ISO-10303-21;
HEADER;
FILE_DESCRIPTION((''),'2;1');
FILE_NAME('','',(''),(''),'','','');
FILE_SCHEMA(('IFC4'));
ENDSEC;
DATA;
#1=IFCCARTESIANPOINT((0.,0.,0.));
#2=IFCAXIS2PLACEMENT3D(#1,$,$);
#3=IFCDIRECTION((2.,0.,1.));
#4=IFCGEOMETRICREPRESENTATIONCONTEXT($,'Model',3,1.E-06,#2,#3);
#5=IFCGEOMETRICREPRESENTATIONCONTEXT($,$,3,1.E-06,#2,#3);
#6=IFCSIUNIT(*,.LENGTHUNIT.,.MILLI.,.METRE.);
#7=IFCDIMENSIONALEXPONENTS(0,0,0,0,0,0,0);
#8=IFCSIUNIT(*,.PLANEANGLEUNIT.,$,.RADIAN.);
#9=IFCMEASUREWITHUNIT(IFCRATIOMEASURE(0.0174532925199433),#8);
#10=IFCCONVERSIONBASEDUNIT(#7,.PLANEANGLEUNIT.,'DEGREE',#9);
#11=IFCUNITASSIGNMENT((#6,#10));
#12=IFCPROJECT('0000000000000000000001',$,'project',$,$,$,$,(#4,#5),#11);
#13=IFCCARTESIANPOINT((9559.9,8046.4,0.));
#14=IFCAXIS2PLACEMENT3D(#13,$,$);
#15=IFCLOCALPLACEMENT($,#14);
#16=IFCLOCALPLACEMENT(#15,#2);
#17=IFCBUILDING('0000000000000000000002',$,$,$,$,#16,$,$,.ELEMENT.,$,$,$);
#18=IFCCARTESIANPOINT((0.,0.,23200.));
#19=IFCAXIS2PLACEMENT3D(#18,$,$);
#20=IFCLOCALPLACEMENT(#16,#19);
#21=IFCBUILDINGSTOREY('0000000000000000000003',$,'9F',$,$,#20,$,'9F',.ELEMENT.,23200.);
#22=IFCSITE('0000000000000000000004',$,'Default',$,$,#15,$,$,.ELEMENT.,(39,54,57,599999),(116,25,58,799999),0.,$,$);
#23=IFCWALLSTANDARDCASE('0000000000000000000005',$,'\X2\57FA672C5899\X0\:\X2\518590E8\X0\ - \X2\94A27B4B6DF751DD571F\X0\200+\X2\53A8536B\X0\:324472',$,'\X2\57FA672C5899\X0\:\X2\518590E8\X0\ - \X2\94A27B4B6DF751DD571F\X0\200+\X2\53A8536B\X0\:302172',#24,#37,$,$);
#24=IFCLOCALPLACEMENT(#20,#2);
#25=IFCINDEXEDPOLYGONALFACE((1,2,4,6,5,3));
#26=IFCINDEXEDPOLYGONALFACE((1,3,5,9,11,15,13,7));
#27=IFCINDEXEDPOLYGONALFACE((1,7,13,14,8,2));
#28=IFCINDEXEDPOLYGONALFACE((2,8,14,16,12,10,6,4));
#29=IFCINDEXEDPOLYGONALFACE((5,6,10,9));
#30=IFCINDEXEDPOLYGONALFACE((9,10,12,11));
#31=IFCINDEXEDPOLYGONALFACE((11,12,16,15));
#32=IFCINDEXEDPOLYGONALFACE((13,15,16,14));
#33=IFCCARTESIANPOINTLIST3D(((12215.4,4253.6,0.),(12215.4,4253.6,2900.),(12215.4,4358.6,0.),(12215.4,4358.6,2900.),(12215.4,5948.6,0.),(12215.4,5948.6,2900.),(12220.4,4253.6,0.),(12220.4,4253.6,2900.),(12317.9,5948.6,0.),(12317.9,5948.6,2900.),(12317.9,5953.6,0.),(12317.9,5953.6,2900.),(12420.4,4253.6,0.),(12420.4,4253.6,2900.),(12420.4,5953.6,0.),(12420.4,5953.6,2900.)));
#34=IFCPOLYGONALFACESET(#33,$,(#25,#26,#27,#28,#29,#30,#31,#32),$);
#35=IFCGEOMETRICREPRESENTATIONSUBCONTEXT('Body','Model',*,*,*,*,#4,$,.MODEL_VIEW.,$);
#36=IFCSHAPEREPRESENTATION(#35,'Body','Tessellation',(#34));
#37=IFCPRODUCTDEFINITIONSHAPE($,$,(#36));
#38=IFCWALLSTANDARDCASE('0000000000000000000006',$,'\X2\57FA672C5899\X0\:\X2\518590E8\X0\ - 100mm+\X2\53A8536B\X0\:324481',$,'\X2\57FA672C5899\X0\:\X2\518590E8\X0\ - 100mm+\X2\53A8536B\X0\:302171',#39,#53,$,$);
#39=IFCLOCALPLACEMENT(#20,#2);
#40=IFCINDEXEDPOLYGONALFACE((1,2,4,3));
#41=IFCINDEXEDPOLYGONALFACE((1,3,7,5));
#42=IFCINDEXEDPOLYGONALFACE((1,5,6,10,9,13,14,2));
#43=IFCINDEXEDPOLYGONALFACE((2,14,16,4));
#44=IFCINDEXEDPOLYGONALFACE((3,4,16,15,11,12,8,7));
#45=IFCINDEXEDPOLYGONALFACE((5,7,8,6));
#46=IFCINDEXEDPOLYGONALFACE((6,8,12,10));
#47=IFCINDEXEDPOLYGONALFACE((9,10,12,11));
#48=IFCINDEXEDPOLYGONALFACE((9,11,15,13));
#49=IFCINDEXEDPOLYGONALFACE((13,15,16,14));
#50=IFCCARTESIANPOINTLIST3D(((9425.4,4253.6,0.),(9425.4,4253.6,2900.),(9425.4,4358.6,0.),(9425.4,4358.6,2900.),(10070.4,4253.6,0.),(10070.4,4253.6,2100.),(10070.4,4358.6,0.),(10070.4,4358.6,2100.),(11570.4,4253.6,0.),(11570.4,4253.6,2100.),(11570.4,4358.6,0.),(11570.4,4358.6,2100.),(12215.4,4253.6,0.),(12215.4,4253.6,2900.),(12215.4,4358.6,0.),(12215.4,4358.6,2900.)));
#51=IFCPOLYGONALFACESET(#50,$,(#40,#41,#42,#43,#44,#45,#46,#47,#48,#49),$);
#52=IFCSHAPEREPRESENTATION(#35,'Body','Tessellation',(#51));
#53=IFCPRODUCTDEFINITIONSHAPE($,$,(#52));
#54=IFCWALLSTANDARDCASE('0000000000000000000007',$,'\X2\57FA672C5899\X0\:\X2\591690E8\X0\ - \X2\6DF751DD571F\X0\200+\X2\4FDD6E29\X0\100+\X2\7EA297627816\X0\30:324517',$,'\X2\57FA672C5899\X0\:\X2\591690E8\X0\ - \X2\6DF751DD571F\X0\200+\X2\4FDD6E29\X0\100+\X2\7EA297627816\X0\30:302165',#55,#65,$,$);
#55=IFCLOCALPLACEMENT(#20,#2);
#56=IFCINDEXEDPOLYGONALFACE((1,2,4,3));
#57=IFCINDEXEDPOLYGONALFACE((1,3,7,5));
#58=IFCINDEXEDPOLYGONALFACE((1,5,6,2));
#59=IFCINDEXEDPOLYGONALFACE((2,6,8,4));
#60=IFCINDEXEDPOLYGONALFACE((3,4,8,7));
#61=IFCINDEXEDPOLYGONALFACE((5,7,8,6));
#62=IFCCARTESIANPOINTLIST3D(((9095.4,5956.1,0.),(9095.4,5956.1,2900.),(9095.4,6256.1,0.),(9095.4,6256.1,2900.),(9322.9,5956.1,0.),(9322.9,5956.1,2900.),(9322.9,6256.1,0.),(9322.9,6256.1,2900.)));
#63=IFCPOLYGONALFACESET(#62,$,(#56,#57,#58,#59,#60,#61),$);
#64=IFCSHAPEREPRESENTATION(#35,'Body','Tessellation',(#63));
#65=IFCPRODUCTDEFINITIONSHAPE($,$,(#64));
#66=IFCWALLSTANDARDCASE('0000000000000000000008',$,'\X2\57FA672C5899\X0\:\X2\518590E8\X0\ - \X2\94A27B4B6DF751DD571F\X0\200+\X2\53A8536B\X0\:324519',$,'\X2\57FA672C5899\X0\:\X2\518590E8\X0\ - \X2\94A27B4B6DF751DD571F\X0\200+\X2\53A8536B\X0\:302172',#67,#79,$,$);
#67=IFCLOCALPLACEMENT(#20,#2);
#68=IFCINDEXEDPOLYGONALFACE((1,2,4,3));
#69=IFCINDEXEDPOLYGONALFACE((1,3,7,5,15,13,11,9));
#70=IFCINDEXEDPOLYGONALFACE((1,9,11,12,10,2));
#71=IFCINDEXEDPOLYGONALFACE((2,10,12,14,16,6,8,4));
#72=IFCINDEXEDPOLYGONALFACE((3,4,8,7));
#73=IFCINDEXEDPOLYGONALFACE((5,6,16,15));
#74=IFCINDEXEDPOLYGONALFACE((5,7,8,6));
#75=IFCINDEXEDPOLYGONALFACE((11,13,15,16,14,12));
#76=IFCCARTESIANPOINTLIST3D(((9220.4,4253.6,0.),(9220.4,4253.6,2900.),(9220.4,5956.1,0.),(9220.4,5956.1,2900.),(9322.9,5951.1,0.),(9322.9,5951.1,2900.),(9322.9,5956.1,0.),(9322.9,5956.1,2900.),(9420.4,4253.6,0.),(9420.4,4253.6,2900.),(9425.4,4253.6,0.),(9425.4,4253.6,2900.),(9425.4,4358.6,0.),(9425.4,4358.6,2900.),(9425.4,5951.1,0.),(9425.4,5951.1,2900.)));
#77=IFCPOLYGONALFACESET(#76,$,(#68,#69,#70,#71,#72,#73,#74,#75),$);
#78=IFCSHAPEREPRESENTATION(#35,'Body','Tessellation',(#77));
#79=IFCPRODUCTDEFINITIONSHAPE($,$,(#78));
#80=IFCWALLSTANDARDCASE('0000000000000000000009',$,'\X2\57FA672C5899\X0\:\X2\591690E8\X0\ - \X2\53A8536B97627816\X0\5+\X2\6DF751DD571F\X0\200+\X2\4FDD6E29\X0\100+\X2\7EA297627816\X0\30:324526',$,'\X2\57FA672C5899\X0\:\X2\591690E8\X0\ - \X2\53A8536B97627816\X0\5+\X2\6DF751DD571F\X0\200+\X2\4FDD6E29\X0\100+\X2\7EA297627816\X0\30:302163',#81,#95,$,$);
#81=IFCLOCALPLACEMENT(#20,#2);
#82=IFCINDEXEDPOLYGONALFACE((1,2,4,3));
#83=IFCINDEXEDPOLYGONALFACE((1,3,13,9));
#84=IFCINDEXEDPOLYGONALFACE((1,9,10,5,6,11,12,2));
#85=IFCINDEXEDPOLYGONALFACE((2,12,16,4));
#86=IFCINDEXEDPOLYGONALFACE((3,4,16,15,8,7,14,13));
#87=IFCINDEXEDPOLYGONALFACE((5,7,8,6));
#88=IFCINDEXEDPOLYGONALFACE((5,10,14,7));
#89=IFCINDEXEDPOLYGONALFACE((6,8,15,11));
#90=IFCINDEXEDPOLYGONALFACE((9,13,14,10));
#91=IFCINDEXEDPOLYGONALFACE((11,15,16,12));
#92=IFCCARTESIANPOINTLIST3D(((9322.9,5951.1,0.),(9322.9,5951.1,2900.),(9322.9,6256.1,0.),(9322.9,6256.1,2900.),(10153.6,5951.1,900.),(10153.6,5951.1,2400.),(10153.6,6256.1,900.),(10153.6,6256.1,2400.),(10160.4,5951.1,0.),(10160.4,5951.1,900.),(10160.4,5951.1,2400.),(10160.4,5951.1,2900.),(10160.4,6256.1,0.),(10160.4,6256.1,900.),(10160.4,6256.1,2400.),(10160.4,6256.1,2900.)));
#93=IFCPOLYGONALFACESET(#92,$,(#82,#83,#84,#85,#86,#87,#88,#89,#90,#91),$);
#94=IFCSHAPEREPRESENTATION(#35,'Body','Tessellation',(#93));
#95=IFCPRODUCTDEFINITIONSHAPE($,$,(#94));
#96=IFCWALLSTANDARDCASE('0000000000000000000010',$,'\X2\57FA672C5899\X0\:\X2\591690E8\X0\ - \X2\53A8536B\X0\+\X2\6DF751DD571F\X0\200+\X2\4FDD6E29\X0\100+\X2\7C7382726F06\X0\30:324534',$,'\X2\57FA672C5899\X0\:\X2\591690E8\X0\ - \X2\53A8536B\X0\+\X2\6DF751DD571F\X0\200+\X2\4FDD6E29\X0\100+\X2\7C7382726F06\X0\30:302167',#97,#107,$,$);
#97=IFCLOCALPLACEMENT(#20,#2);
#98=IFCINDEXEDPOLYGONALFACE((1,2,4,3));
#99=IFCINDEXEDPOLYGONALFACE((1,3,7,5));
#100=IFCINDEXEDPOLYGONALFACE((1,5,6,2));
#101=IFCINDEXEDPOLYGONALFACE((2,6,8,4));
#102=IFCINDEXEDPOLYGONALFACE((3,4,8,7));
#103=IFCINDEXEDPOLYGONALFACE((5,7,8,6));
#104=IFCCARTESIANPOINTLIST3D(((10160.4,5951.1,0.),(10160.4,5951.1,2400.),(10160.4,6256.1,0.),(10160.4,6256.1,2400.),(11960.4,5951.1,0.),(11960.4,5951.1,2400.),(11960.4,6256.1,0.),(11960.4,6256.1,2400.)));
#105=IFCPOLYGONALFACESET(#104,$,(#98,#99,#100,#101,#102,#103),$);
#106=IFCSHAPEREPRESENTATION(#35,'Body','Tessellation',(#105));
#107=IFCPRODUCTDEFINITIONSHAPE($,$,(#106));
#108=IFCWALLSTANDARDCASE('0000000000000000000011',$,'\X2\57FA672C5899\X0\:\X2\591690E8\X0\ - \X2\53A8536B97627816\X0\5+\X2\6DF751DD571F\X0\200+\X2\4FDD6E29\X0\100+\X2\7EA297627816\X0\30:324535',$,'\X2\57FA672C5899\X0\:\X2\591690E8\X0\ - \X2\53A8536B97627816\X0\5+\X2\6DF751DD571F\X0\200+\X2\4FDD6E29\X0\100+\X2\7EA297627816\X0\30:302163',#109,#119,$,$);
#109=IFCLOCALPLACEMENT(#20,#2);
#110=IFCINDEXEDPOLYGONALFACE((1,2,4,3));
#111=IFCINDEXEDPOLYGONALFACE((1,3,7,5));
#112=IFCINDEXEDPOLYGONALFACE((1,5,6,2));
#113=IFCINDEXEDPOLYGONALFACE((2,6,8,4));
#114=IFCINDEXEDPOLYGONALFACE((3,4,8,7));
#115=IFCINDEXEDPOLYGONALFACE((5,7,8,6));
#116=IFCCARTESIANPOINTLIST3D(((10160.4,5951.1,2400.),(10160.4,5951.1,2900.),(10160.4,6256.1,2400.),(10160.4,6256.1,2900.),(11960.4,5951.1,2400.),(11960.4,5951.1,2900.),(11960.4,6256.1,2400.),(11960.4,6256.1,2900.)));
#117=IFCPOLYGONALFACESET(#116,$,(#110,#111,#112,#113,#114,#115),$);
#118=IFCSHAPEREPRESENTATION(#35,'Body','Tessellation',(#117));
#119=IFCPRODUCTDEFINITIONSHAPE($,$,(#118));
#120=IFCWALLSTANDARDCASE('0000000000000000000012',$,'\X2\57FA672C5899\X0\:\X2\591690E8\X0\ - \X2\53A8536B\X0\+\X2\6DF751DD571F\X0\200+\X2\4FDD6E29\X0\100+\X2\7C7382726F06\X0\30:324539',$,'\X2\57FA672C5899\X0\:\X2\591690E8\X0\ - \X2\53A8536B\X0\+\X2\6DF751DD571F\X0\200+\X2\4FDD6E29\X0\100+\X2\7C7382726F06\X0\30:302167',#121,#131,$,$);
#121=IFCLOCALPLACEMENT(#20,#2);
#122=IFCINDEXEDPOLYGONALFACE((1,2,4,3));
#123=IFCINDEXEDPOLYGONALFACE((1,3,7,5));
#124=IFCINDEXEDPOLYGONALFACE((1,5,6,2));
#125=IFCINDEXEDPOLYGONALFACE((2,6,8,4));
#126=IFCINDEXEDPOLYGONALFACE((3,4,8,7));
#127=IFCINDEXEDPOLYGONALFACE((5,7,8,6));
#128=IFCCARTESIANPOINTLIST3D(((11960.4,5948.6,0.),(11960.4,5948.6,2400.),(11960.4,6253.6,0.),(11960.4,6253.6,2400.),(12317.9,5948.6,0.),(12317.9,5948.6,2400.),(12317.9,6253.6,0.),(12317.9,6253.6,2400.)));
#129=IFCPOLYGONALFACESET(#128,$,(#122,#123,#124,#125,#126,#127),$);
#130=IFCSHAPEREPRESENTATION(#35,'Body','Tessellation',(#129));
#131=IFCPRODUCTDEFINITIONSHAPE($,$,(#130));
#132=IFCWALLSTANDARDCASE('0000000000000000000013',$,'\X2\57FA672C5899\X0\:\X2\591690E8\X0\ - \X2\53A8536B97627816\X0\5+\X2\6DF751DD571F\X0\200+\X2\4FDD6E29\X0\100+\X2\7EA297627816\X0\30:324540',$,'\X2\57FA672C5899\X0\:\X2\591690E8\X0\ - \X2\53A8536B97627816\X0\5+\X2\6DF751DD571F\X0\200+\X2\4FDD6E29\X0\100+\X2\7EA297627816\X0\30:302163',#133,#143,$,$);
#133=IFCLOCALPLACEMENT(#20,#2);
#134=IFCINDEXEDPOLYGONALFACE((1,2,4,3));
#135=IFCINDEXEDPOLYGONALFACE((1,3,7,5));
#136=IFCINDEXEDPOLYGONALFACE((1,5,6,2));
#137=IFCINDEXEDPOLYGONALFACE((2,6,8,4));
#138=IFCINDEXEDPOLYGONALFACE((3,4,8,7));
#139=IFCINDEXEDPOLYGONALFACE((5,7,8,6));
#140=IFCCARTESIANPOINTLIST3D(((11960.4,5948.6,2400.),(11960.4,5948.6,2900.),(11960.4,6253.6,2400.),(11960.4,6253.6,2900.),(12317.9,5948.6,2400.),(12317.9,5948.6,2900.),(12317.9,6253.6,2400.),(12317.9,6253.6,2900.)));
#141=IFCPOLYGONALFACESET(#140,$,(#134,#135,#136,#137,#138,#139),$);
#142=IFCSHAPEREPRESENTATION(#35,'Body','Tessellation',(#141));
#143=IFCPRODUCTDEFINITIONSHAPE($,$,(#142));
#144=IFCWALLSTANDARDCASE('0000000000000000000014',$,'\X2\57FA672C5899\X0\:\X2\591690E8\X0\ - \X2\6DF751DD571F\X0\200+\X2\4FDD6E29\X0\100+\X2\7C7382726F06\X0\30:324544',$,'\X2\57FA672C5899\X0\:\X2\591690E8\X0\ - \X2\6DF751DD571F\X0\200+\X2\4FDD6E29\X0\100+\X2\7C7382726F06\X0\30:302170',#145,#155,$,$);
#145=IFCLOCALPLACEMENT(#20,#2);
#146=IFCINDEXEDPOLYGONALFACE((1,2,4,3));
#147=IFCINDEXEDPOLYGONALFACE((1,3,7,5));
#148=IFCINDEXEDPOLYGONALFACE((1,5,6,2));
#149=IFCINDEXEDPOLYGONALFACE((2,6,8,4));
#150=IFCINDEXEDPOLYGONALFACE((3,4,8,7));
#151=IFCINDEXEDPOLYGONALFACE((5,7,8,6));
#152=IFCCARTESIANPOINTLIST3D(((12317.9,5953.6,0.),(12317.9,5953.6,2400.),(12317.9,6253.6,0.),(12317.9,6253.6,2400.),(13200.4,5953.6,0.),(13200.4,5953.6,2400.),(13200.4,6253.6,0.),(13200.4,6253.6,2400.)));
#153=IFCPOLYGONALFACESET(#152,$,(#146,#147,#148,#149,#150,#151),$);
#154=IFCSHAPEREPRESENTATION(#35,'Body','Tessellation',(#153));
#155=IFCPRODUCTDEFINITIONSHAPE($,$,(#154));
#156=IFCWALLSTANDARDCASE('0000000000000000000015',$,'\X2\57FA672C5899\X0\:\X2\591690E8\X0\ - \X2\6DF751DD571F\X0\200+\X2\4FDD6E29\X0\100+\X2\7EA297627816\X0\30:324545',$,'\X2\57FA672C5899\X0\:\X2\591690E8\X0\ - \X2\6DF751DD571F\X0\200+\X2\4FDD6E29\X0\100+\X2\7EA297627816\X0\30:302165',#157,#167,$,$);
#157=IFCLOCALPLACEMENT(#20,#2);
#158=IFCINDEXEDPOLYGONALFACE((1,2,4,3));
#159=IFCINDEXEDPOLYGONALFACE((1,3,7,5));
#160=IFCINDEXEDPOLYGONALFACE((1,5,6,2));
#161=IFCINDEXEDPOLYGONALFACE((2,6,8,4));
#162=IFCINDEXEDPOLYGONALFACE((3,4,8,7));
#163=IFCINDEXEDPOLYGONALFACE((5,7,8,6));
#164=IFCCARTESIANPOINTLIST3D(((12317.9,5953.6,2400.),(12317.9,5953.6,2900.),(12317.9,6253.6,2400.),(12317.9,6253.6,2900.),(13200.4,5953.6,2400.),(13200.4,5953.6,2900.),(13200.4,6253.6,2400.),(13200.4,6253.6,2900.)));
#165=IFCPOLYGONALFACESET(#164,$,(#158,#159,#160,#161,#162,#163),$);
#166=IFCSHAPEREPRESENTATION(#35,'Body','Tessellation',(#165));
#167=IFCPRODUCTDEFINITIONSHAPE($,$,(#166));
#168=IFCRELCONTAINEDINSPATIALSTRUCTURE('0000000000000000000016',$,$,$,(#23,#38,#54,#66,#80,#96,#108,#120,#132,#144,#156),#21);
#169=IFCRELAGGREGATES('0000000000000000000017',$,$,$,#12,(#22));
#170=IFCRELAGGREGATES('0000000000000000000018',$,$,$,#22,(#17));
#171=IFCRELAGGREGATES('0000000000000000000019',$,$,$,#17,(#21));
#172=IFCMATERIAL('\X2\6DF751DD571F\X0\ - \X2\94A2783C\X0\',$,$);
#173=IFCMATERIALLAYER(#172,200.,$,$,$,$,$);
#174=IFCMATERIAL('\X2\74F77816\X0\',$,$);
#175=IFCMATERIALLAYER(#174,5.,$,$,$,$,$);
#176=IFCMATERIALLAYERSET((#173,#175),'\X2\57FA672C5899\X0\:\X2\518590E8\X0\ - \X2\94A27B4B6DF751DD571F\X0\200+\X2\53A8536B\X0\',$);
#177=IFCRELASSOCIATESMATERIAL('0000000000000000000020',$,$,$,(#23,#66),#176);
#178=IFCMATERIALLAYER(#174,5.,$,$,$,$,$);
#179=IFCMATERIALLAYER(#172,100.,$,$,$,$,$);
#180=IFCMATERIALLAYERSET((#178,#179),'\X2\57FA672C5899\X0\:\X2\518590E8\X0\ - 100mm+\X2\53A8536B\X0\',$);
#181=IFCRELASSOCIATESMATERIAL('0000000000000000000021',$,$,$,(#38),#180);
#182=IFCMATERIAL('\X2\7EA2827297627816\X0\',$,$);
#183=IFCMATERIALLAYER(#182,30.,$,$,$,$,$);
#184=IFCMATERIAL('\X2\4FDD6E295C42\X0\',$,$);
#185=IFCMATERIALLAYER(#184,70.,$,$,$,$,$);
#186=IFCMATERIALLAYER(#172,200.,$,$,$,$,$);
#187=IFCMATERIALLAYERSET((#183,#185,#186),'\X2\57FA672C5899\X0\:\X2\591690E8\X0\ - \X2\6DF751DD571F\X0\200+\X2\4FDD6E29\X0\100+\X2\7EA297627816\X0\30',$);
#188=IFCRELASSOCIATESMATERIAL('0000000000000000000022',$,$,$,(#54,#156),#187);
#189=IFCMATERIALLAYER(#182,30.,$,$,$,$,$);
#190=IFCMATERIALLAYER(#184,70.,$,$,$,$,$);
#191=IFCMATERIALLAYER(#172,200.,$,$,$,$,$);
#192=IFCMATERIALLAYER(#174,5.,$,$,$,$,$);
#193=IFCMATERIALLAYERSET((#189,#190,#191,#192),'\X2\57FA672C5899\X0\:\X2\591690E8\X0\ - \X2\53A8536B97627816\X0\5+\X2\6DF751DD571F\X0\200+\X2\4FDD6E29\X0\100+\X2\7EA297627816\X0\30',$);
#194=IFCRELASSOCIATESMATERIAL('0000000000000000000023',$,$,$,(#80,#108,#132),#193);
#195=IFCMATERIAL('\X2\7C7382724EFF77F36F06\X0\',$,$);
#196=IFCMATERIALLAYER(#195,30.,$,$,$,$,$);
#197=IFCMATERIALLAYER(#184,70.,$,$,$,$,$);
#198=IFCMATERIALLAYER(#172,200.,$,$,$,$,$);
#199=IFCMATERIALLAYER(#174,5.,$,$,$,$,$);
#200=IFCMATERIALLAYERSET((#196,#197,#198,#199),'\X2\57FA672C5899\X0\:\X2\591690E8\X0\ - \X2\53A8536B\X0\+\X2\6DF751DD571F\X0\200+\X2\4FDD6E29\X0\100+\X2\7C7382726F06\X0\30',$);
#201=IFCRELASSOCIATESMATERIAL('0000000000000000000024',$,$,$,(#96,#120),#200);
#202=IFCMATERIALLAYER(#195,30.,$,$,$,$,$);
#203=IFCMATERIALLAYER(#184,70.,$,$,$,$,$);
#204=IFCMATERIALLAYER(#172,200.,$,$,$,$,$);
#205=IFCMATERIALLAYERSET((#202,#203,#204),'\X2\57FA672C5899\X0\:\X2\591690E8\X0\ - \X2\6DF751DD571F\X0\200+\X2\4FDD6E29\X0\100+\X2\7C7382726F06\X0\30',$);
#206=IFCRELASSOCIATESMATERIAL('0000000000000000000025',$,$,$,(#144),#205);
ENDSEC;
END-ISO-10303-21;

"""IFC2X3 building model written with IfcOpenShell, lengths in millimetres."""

from ifc_helpers import new_model, entity, si_unit, converted_unit, direction, frame, frame_2d, origin, place, context, subcontext, project, spatial, polyline, rectangle, outline, extrude, material, layer, layer_set, layer_usage, element, save


model = new_model("IFC2X3")

# Units and contexts
model_context = context("Model", 3, precision=1e-06, world=origin(), true_north=direction((2.0, 0.0, 1.0)))
context_of_model = context(None, 3, precision=1e-06, world=origin(), true_north=direction((2.0, 0.0, 1.0)))
body_context = subcontext(model_context, "Body", "Model", "MODEL_VIEW")
ifc_project = project(units=[si_unit("LENGTHUNIT", "METRE", prefix="MILLI"), converted_unit("PLANEANGLEUNIT", "DEGREE", entity("IfcRatioMeasure", 0.0174532925199433), si_unit("PLANEANGLEUNIT", "RADIAN"), dimensions=[0, 0, 0, 0, 0, 0, 0])], contexts=[model_context, context_of_model])

# Site, building, storey
site_placement = place(None, frame((9559.9, 8046.4, 0.0)))
site = spatial("IfcSite", under=ifc_project, at=site_placement, Name="Default", CompositionType="ELEMENT", RefLatitude=(39, 54, 57, 599999), RefLongitude=(116, 25, 58, 799999), RefElevation=0.0)
building_placement = place(site_placement, origin())
building = spatial("IfcBuilding", under=site, at=building_placement, CompositionType="ELEMENT")
storey_placement = place(building_placement, frame((0.0, 0.0, 23200.0)))
storey = spatial("IfcBuildingStorey", under=building, at=storey_placement, Name="9F", LongName="9F", CompositionType="ELEMENT", Elevation=23200.0)

# Shared definitions
ifc_material_1 = material(Name="红色面砖")
ifc_layer_1 = layer(ifc_material_1, 30.0)
ifc_material_2 = material(Name="保温层")
ifc_layer_2 = layer(ifc_material_2, 70.0)
ifc_material_3 = material(Name="混凝土 - 钢砼")
ifc_layer_3 = layer(ifc_material_3, 200.0)
ifc_layer_set_1 = layer_set([ifc_layer_1, ifc_layer_2, ifc_layer_3], Name="基本墙:外部 - 混凝土200+保温100+红面砖30")

# Wall
ifc_layer_4 = layer(ifc_material_3, 200.0)
ifc_material_4 = material(Name="瓷砖")
ifc_layer_5 = layer(ifc_material_4, 5.0)
ifc_layer_set_2 = layer_set([ifc_layer_4, ifc_layer_5], Name="基本墙:内部 - 钢筋混凝土200+厨卫")
ifc_layer_usage_1 = layer_usage(ifc_layer_set_2, "AXIS2", "NEGATIVE", 102.5)
wall_1_placement = place(storey_placement, frame((12317.9, 5953.6, 0.0), z_axis=(0.0, 0.0, 1.0), x_axis=(0.0, -1.0, 0.0)))
element("IfcWallStandardCase", 1, at=wall_1_placement, inside=storey, material=ifc_layer_usage_1, Name="基本墙:内部 - 钢筋混凝土200+厨卫:324472", ObjectType="基本墙:内部 - 钢筋混凝土200+厨卫:302172", context=body_context, shape_type="SweptSolid", body=[
    extrude(outline(polyline([(1700.0, -102.5), (1700.0, -97.5), (1700.0, 102.5), (0.0, 102.5), (0.0, 0.0), (5.0, 0.0), (5.0, -102.5), (1595.0, -102.5), (1700.0, -102.5)])), origin(), (0.0, 0.0, 1.0), 2900.0),
])

# Wall, opening
ifc_layer_6 = layer(ifc_material_4, 5.0)
ifc_layer_7 = layer(ifc_material_3, 100.0)
ifc_layer_set_3 = layer_set([ifc_layer_6, ifc_layer_7], Name="基本墙:内部 - 100mm+厨卫")
ifc_layer_usage_2 = layer_usage(ifc_layer_set_3, "AXIS2", "POSITIVE", -52.5)
wall_2_placement = place(storey_placement, frame((12215.4, 4306.1, 0.0), z_axis=(0.0, 0.0, 1.0), x_axis=(-1.0, 0.0, 0.0)))
wall_2 = element("IfcWallStandardCase", 2, at=wall_2_placement, inside=storey, material=ifc_layer_usage_2, Name="基本墙:内部 - 100mm+厨卫:324481", ObjectType="基本墙:内部 - 100mm+厨卫:302171", context=body_context, shape_type="SweptSolid", body=[
    extrude(rectangle(XDim=2790.0, YDim=105.0, at=frame_2d((1395.0, 0.0), x_axis=(-1.0, 0.0))), origin(), (0.0, 0.0, 1.0), 2900.0),
])
opening_1_placement = place(wall_2_placement, frame((645.0, -52.5, 0.0)))
element("IfcOpeningElement", 3, at=opening_1_placement, cuts=wall_2, ObjectType="Opening", context=body_context, shape_type="SweptSolid", body=[
    extrude(rectangle(XDim=2100.0, YDim=1500.0, at=frame_2d((1050.0, 750.0), x_axis=(1.0, 0.0))), frame((0.0, 0.0, 0.0), z_axis=(0.0, 1.0, 0.0), x_axis=(0.0, 0.0, 1.0)), (0.0, 0.0, 1.0), 105.0),
])

# Walls
ifc_layer_usage_3 = layer_usage(ifc_layer_set_1, "AXIS2", "POSITIVE", -150.0)
wall_3_placement = place(storey_placement, frame((9322.9, 6106.1, 0.0), z_axis=(0.0, 0.0, 1.0), x_axis=(-1.0, 0.0, 0.0)))
element("IfcWallStandardCase", 4, at=wall_3_placement, inside=storey, material=ifc_layer_usage_3, Name="基本墙:外部 - 混凝土200+保温100+红面砖30:324517", ObjectType="基本墙:外部 - 混凝土200+保温100+红面砖30:302165", context=body_context, shape_type="SweptSolid", body=[
    extrude(rectangle(XDim=227.5, YDim=300.0, at=frame_2d((113.8, 0.0), x_axis=(-1.0, 0.0))), origin(), (0.0, 0.0, 1.0), 2900.0),
])
ifc_layer_usage_4 = layer_usage(ifc_layer_set_2, "AXIS2", "POSITIVE", -102.5)
wall_4_placement = place(storey_placement, frame((9322.9, 5956.1, 0.0), z_axis=(0.0, 0.0, 1.0), x_axis=(0.0, -1.0, 0.0)))
element("IfcWallStandardCase", 5, at=wall_4_placement, inside=storey, material=ifc_layer_usage_4, Name="基本墙:内部 - 钢筋混凝土200+厨卫:324519", ObjectType="基本墙:内部 - 钢筋混凝土200+厨卫:302172", context=body_context, shape_type="SweptSolid", body=[
    extrude(outline(polyline([(1702.5, -102.5), (1702.5, 97.5), (1702.5, 102.5), (1597.5, 102.5), (5.0, 102.5), (5.0, 0.0), (0.0, 0.0), (0.0, -102.5), (1702.5, -102.5)])), origin(), (0.0, 0.0, 1.0), 2900.0),
])

# Wall, opening
ifc_layer_8 = layer(ifc_material_1, 30.0)
ifc_layer_9 = layer(ifc_material_2, 70.0)
ifc_layer_10 = layer(ifc_material_3, 200.0)
ifc_layer_11 = layer(ifc_material_4, 5.0)
ifc_layer_set_4 = layer_set([ifc_layer_8, ifc_layer_9, ifc_layer_10, ifc_layer_11], Name="基本墙:外部 - 厨卫面砖5+混凝土200+保温100+红面砖30")
ifc_layer_usage_5 = layer_usage(ifc_layer_set_4, "AXIS2", "POSITIVE", -152.5)
wall_5_placement = place(storey_placement, frame((10160.4, 6103.6, 0.0), z_axis=(0.0, 0.0, 1.0), x_axis=(-1.0, 0.0, 0.0)))
wall_5 = element("IfcWallStandardCase", 6, at=wall_5_placement, inside=storey, material=ifc_layer_usage_5, Name="基本墙:外部 - 厨卫面砖5+混凝土200+保温100+红面砖30:324526", ObjectType="基本墙:外部 - 厨卫面砖5+混凝土200+保温100+红面砖30:302163", context=body_context, shape_type="SweptSolid", body=[
    extrude(rectangle(XDim=837.5, YDim=305.0, at=frame_2d((418.8, 0.0), x_axis=(-1.0, 0.0))), origin(), (0.0, 0.0, 1.0), 2900.0),
])
opening_2_placement = place(wall_5_placement, frame((6.7, 152.5, 900.0)))
element("IfcOpeningElement", 7, at=opening_2_placement, cuts=wall_5, ObjectType="Opening", context=body_context, shape_type="SweptSolid", body=[
    extrude(rectangle(XDim=1500.0, YDim=1800.0, at=frame_2d((750.0, 900.0), x_axis=(1.0, 0.0))), frame((0.0, 0.0, 0.0), z_axis=(0.0, -1.0, 0.0), x_axis=(0.0, 0.0, 1.0)), (0.0, 0.0, 1.0), 305.0),
])

# Walls
ifc_material_5 = material(Name="米色仿石漆")
ifc_layer_12 = layer(ifc_material_5, 30.0)
ifc_layer_13 = layer(ifc_material_2, 70.0)
ifc_layer_14 = layer(ifc_material_3, 200.0)
ifc_layer_15 = layer(ifc_material_4, 5.0)
ifc_layer_set_5 = layer_set([ifc_layer_12, ifc_layer_13, ifc_layer_14, ifc_layer_15], Name="基本墙:外部 - 厨卫+混凝土200+保温100+米色漆30")
ifc_layer_usage_6 = layer_usage(ifc_layer_set_5, "AXIS2", "POSITIVE", -152.5)
wall_6_placement = place(storey_placement, frame((11960.4, 6103.6, 0.0), z_axis=(0.0, 0.0, 1.0), x_axis=(-1.0, 0.0, 0.0)))
element("IfcWallStandardCase", 8, at=wall_6_placement, inside=storey, material=ifc_layer_usage_6, Name="基本墙:外部 - 厨卫+混凝土200+保温100+米色漆30:324534", ObjectType="基本墙:外部 - 厨卫+混凝土200+保温100+米色漆30:302167", context=body_context, shape_type="SweptSolid", body=[
    extrude(rectangle(XDim=1800.0, YDim=305.0, at=frame_2d((900.0, 0.0), x_axis=(-1.0, 0.0))), origin(), (0.0, 0.0, 1.0), 2400.0),
])
ifc_layer_usage_7 = layer_usage(ifc_layer_set_4, "AXIS2", "POSITIVE", -152.5)
wall_7_placement = place(storey_placement, frame((11960.4, 6103.6, 2400.0), z_axis=(0.0, 0.0, 1.0), x_axis=(-1.0, 0.0, 0.0)))
element("IfcWallStandardCase", 9, at=wall_7_placement, inside=storey, material=ifc_layer_usage_7, Name="基本墙:外部 - 厨卫面砖5+混凝土200+保温100+红面砖30:324535", ObjectType="基本墙:外部 - 厨卫面砖5+混凝土200+保温100+红面砖30:302163", context=body_context, shape_type="SweptSolid", body=[
    extrude(rectangle(XDim=1800.0, YDim=305.0, at=frame_2d((900.0, 0.0), x_axis=(-1.0, 0.0))), origin(), (0.0, 0.0, 1.0), 500.0),
])
ifc_layer_usage_8 = layer_usage(ifc_layer_set_5, "AXIS2", "POSITIVE", -152.5)
wall_8_placement = place(storey_placement, frame((12317.9, 6101.1, 0.0), z_axis=(0.0, 0.0, 1.0), x_axis=(-1.0, 0.0, 0.0)))
element("IfcWallStandardCase", 10, at=wall_8_placement, inside=storey, material=ifc_layer_usage_8, Name="基本墙:外部 - 厨卫+混凝土200+保温100+米色漆30:324539", ObjectType="基本墙:外部 - 厨卫+混凝土200+保温100+米色漆30:302167", context=body_context, shape_type="SweptSolid", body=[
    extrude(rectangle(XDim=357.5, YDim=305.0, at=frame_2d((178.8, 0.0), x_axis=(-1.0, 0.0))), origin(), (0.0, 0.0, 1.0), 2400.0),
])
ifc_layer_usage_9 = layer_usage(ifc_layer_set_4, "AXIS2", "POSITIVE", -152.5)
wall_9_placement = place(storey_placement, frame((12317.9, 6101.1, 2400.0), z_axis=(0.0, 0.0, 1.0), x_axis=(-1.0, 0.0, 0.0)))
element("IfcWallStandardCase", 11, at=wall_9_placement, inside=storey, material=ifc_layer_usage_9, Name="基本墙:外部 - 厨卫面砖5+混凝土200+保温100+红面砖30:324540", ObjectType="基本墙:外部 - 厨卫面砖5+混凝土200+保温100+红面砖30:302163", context=body_context, shape_type="SweptSolid", body=[
    extrude(rectangle(XDim=357.5, YDim=305.0, at=frame_2d((178.8, 0.0), x_axis=(-1.0, 0.0))), origin(), (0.0, 0.0, 1.0), 500.0),
])
ifc_layer_16 = layer(ifc_material_5, 30.0)
ifc_layer_17 = layer(ifc_material_2, 70.0)
ifc_layer_18 = layer(ifc_material_3, 200.0)
ifc_layer_set_6 = layer_set([ifc_layer_16, ifc_layer_17, ifc_layer_18], Name="基本墙:外部 - 混凝土200+保温100+米色漆30")
ifc_layer_usage_10 = layer_usage(ifc_layer_set_6, "AXIS2", "POSITIVE", -150.0)
wall_10_placement = place(storey_placement, frame((13200.4, 6103.6, 0.0), z_axis=(0.0, 0.0, 1.0), x_axis=(-1.0, 0.0, 0.0)))
element("IfcWallStandardCase", 12, at=wall_10_placement, inside=storey, material=ifc_layer_usage_10, Name="基本墙:外部 - 混凝土200+保温100+米色漆30:324544", ObjectType="基本墙:外部 - 混凝土200+保温100+米色漆30:302170", context=body_context, shape_type="SweptSolid", body=[
    extrude(rectangle(XDim=882.5, YDim=300.0, at=frame_2d((441.2, 0.0), x_axis=(-1.0, 0.0))), origin(), (0.0, 0.0, 1.0), 2400.0),
])
ifc_layer_usage_11 = layer_usage(ifc_layer_set_1, "AXIS2", "POSITIVE", -150.0)
wall_11_placement = place(storey_placement, frame((13200.4, 6103.6, 2400.0), z_axis=(0.0, 0.0, 1.0), x_axis=(-1.0, 0.0, 0.0)))
element("IfcWallStandardCase", 13, at=wall_11_placement, inside=storey, material=ifc_layer_usage_11, Name="基本墙:外部 - 混凝土200+保温100+红面砖30:324545", ObjectType="基本墙:外部 - 混凝土200+保温100+红面砖30:302165", context=body_context, shape_type="SweptSolid", body=[
    extrude(rectangle(XDim=882.5, YDim=300.0, at=frame_2d((441.2, 0.0), x_axis=(-1.0, 0.0))), origin(), (0.0, 0.0, 1.0), 500.0),
])

save(model, "model.ifc")
